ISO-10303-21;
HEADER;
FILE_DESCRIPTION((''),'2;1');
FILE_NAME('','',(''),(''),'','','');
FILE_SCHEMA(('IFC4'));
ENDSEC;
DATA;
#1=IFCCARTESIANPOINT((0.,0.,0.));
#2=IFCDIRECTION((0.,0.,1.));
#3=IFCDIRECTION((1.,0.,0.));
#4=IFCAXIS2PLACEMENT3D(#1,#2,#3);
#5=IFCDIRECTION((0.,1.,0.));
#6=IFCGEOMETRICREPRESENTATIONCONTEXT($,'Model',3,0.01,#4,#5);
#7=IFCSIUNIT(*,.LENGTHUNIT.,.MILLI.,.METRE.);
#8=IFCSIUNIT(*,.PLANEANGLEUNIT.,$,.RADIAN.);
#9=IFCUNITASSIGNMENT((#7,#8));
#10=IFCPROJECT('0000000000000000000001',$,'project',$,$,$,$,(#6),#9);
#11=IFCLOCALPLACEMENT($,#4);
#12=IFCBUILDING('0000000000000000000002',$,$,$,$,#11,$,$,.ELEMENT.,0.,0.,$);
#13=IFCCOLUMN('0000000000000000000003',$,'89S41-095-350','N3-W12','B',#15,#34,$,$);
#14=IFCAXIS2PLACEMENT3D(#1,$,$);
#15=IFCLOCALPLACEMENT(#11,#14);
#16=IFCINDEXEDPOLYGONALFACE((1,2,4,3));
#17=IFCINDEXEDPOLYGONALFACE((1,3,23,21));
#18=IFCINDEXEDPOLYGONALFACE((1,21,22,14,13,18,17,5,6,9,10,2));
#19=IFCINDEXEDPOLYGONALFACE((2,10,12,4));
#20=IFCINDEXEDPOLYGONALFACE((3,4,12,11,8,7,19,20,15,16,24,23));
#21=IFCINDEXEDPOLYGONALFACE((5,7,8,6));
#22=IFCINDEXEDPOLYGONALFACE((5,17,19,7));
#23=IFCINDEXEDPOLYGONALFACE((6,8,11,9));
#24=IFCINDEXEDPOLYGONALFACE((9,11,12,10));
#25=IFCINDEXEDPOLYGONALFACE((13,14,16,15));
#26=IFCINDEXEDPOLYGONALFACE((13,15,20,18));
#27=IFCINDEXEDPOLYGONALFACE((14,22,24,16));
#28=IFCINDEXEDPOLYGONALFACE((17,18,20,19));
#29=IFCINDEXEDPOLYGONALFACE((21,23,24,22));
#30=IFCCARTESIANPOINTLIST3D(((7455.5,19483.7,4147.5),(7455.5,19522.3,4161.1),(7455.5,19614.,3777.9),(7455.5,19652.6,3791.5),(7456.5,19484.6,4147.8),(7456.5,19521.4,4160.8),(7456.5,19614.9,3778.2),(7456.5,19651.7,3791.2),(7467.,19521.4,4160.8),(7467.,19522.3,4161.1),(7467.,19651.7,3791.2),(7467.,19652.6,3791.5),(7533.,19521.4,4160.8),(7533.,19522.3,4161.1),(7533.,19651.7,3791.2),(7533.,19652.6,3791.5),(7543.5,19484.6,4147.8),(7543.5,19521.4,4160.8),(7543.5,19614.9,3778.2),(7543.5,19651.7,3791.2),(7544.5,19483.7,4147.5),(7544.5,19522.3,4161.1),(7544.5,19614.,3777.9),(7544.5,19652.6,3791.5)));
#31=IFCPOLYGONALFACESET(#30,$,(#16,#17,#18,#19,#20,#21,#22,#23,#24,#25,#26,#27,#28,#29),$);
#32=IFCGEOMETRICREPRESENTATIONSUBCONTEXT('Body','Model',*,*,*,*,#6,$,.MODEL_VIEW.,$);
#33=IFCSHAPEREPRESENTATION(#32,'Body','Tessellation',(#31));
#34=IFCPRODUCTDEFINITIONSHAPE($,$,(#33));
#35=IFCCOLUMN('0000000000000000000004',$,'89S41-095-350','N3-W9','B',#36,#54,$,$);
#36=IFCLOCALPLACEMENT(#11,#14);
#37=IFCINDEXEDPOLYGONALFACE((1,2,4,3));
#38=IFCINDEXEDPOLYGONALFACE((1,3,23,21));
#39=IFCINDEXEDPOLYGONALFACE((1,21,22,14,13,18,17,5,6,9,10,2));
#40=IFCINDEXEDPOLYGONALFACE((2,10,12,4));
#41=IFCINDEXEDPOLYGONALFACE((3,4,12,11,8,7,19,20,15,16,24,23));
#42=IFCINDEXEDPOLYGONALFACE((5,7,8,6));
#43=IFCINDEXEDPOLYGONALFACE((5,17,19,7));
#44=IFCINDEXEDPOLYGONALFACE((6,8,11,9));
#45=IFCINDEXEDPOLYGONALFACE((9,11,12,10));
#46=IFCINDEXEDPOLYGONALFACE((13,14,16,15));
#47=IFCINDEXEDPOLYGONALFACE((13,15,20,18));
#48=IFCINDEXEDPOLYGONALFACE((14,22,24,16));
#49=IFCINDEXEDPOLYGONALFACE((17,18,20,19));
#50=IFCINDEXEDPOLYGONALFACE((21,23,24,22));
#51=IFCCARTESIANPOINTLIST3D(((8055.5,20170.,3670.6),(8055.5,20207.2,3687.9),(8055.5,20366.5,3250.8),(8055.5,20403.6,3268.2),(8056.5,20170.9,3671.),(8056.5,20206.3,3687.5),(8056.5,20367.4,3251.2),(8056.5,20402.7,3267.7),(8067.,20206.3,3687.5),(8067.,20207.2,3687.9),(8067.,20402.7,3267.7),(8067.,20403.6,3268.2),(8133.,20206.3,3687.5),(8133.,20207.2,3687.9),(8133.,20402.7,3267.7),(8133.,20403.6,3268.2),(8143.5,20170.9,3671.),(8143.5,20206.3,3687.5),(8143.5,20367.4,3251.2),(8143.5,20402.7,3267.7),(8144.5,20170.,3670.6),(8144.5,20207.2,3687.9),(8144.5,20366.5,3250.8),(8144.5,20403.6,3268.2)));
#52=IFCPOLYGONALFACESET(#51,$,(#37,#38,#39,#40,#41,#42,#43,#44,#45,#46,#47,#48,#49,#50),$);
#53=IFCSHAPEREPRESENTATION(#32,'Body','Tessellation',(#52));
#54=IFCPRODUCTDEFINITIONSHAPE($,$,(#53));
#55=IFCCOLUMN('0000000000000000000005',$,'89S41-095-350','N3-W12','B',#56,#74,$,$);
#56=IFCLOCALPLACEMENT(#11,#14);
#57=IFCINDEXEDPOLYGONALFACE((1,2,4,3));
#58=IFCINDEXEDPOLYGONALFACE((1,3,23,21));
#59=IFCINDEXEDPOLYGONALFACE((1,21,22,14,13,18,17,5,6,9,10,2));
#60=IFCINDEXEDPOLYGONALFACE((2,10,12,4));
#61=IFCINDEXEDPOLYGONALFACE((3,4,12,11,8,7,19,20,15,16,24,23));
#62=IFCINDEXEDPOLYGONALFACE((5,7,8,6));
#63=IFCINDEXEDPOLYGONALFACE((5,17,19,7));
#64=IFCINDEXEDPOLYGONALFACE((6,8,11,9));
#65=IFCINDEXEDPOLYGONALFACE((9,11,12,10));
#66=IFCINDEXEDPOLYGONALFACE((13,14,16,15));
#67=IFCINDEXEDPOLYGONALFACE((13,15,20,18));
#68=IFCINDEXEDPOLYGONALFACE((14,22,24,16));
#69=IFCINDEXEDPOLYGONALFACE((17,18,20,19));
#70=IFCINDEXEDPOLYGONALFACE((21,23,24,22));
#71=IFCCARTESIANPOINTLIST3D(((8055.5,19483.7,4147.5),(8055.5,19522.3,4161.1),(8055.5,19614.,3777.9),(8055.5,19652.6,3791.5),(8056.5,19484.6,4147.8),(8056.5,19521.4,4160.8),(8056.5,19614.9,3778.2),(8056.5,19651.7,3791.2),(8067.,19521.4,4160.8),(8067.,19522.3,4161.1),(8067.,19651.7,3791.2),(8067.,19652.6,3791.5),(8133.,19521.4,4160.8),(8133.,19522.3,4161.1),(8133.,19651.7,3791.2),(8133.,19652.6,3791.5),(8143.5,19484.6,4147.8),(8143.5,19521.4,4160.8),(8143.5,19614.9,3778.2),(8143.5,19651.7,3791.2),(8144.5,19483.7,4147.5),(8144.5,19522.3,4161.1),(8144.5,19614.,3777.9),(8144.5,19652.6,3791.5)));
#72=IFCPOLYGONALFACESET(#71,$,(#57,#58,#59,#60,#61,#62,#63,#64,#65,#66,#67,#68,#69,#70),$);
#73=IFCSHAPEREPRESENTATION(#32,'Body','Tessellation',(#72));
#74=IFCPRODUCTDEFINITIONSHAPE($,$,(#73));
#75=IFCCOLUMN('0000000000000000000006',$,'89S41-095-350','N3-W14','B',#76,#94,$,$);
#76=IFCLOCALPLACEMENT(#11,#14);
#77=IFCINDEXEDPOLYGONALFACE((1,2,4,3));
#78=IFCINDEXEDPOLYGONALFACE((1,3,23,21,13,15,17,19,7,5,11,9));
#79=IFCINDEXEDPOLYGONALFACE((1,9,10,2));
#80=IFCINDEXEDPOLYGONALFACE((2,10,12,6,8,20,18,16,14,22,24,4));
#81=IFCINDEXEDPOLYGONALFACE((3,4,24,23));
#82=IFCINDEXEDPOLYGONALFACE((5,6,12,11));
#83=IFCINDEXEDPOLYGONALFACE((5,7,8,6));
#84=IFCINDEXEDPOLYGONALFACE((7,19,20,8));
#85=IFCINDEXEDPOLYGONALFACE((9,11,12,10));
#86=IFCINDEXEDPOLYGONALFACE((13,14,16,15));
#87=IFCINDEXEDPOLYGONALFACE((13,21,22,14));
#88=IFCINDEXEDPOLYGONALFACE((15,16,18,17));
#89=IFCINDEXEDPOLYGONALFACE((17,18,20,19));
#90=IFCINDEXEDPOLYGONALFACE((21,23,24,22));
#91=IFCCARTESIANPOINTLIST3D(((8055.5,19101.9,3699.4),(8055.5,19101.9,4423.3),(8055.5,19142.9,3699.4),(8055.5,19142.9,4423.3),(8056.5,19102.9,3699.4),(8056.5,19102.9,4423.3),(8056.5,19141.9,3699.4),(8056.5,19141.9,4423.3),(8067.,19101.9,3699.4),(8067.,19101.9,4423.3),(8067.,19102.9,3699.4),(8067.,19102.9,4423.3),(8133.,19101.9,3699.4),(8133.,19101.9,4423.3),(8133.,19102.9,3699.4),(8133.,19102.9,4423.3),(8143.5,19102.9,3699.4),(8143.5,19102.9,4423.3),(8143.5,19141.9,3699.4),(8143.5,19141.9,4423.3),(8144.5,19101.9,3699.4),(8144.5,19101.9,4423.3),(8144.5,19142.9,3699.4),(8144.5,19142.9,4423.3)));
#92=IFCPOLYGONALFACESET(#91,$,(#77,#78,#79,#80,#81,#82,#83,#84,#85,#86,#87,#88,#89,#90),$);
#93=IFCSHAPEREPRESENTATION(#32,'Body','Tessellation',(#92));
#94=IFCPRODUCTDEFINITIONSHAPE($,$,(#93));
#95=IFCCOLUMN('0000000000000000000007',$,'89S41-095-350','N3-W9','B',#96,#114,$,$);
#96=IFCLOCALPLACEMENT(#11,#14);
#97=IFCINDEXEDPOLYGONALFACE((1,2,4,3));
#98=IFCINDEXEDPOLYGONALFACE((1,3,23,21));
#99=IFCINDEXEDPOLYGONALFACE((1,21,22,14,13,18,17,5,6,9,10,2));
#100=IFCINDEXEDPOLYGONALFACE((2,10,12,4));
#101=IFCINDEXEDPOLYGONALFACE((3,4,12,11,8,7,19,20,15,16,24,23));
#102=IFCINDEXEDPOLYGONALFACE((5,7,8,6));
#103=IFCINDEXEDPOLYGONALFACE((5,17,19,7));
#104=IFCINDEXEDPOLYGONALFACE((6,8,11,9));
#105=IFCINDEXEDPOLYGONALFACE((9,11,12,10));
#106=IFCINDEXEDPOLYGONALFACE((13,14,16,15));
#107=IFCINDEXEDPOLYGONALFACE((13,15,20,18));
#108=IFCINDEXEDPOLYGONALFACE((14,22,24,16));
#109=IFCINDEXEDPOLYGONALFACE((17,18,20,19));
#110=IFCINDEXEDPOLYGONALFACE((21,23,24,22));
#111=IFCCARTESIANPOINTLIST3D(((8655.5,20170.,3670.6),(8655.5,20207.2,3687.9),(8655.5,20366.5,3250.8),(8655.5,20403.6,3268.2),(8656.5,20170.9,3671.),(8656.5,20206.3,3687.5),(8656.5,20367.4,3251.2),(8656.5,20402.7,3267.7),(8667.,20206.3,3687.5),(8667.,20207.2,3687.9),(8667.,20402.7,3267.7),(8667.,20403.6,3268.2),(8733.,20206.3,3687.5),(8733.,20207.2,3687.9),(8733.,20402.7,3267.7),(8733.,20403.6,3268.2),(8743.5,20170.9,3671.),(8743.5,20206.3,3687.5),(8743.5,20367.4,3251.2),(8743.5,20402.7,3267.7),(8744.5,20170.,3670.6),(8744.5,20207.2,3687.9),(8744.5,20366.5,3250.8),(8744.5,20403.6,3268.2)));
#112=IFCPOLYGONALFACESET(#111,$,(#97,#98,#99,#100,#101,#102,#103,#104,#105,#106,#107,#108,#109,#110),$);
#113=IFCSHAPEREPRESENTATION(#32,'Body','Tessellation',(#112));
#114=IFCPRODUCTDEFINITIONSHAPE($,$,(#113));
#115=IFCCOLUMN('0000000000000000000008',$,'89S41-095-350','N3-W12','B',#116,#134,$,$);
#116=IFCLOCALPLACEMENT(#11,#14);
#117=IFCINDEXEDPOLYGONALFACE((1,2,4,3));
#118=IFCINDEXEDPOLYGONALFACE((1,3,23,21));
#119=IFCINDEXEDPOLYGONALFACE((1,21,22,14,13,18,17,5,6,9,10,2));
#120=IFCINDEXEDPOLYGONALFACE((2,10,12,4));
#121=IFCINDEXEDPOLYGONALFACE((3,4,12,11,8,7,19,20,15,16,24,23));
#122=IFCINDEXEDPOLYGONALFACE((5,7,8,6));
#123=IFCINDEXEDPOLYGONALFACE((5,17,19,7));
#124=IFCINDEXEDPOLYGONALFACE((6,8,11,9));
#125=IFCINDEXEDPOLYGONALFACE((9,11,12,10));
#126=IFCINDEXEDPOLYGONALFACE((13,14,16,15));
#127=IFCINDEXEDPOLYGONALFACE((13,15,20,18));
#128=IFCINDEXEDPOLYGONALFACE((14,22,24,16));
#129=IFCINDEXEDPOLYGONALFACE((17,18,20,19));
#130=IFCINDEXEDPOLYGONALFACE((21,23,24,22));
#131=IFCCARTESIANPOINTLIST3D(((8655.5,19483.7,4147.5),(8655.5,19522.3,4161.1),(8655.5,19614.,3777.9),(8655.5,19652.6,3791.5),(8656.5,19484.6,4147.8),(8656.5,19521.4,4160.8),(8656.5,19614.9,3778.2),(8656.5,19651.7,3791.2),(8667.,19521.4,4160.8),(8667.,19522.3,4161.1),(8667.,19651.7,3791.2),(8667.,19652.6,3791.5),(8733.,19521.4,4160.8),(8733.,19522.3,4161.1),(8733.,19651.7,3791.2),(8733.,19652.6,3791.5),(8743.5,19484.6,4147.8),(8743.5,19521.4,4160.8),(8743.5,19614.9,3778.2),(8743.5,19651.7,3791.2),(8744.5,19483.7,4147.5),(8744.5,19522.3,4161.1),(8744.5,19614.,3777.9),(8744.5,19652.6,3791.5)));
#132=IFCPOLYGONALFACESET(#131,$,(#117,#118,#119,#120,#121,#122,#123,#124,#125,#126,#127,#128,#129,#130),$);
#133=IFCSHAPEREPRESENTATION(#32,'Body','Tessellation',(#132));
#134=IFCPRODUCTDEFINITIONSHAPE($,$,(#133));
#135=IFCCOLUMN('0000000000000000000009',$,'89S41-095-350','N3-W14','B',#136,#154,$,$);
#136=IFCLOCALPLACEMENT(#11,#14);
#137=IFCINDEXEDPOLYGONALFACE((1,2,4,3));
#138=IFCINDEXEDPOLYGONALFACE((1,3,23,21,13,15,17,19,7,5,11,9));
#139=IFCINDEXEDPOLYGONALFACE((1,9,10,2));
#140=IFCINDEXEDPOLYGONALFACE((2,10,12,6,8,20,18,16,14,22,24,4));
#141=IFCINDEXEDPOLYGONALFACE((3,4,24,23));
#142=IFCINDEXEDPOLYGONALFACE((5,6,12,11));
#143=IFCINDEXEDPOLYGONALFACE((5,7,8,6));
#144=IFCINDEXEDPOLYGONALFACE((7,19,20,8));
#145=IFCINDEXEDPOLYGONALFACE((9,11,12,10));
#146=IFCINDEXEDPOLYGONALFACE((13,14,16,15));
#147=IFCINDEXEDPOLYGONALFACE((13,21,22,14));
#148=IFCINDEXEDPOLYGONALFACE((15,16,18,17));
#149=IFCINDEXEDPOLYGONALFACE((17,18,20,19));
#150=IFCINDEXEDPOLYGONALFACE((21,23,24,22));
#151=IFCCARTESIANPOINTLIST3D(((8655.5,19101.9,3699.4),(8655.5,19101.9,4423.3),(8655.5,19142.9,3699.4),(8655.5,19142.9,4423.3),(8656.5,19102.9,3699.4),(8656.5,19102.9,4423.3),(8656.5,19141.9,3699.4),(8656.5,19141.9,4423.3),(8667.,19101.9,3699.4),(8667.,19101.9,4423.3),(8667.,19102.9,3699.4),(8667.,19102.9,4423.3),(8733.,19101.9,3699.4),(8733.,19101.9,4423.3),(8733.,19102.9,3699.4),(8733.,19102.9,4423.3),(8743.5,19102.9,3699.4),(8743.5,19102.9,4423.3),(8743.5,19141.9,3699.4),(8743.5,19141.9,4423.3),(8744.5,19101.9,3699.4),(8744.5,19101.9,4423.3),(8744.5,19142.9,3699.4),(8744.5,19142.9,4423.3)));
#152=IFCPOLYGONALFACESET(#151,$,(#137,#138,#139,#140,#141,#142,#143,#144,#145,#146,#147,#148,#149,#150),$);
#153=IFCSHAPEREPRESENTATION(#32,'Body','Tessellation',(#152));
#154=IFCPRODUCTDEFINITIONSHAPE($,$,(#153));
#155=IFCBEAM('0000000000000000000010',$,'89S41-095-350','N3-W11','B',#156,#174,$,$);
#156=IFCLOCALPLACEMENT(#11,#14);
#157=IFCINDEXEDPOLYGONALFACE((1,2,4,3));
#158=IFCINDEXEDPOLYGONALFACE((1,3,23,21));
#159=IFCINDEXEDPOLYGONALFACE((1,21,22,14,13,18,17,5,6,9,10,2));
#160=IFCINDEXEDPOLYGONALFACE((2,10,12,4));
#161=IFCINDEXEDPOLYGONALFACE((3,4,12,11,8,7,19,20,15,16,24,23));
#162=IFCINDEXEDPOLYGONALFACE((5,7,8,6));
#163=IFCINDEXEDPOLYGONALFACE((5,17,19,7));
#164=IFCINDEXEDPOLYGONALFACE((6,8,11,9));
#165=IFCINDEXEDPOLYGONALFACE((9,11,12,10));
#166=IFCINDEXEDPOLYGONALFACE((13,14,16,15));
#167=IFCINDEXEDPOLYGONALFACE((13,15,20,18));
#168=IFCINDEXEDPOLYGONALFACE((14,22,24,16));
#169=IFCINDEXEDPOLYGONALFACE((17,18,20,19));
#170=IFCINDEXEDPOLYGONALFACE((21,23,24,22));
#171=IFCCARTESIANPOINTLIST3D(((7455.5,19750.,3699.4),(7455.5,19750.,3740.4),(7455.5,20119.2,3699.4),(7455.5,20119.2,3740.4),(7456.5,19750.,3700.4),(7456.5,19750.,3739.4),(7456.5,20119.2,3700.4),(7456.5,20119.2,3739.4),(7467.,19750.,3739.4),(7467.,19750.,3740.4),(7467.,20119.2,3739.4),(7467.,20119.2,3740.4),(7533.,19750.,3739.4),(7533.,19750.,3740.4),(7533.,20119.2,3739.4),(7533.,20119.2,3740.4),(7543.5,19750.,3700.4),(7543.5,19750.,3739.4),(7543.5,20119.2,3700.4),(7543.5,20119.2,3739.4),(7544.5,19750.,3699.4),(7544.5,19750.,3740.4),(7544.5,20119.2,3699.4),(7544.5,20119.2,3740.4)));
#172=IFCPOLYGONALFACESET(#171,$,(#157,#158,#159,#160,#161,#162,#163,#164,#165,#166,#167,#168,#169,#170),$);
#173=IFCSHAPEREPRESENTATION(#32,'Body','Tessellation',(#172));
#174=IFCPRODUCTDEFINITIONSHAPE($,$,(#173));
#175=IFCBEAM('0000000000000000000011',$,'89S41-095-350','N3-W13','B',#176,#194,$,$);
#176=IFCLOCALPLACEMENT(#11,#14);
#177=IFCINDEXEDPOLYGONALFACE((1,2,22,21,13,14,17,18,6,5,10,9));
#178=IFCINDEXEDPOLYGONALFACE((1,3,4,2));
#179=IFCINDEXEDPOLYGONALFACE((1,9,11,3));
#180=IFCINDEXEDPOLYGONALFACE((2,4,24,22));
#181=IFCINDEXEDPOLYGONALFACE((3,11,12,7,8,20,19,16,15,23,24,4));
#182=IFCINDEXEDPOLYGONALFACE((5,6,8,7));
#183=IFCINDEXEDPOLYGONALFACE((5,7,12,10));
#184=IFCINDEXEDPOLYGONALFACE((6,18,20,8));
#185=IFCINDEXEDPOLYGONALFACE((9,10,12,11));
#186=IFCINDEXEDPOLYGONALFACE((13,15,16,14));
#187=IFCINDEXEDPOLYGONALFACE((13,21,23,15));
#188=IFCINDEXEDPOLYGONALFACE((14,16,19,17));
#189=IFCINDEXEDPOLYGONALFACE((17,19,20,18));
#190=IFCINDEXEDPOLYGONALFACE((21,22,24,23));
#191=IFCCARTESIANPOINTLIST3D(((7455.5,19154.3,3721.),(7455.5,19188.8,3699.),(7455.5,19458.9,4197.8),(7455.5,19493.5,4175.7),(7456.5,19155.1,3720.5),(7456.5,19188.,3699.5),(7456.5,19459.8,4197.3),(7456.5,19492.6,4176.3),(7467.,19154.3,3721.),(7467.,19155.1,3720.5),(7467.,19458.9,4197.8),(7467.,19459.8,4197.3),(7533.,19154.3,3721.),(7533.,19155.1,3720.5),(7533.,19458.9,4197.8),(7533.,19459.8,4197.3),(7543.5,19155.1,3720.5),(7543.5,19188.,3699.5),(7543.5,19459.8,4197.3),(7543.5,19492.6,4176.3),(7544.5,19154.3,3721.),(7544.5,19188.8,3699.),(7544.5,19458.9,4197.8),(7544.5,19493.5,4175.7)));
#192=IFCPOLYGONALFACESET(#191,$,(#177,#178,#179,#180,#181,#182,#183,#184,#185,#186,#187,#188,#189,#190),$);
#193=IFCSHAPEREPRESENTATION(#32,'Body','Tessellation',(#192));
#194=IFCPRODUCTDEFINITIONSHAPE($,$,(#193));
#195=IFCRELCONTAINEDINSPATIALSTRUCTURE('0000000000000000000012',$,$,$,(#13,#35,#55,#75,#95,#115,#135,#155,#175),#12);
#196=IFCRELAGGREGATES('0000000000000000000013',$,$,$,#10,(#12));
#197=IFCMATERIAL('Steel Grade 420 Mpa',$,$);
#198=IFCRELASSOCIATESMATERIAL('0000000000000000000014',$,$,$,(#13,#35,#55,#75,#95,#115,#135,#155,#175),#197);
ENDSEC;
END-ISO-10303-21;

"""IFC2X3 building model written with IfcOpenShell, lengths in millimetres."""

from ifc_helpers import new_model, si_unit, direction, frame, origin, origin_with_axes, origin_2d_with_axis, place, context, subcontext, project, spatial, c_section, extrude, source, transform, mapped, material, element, save


model = new_model("IFC2X3")

# Units and contexts
model_context = context("Model", 3, precision=0.01, world=origin_with_axes(), true_north=direction((0.0, 1.0, 0.0)))
body_context = subcontext(model_context, "Body", "Model", "MODEL_VIEW")
ifc_project = project(units=[si_unit("LENGTHUNIT", "METRE", prefix="MILLI"), si_unit("PLANEANGLEUNIT", "RADIAN")], contexts=[model_context])

# Building
building_placement = place(None, origin_with_axes())
building = spatial("IfcBuilding", under=ifc_project, at=building_placement, CompositionType="ELEMENT", ElevationOfRefHeight=0.0, ElevationOfTerrain=0.0)

# Columns
ifc_material = material(Name="Steel Grade 420 Mpa")
shared_shape_1 = source(origin(), body_context, "Body", "SweptSolid", [
    extrude(c_section(Depth=89.0, Width=41.0, WallThickness=1.0, Girth=11.5, at=origin_2d_with_axis()), origin_with_axes(), (0.0, 0.0, 1.0), 391.9),
])
column_1_placement = place(None, frame((7500.0, 19633.3, 3784.7), z_axis=(0.0, -0.33255, 0.943086), x_axis=(0.0, 0.943086, 0.33255)))
element("IfcColumn", 1, at=column_1_placement, inside=building, material=ifc_material, Name="89S41-095-350", Description="N3-W12", ObjectType="B", context=body_context, shape_type="MappedRepresentation", body=[
    mapped(shared_shape_1, transform((0.0, 0.0, 0.0), scale=1.0)),
])
shared_shape_2 = source(origin(), body_context, "Body", "SweptSolid", [
    extrude(c_section(Depth=89.0, Width=41.0, WallThickness=1.0, Girth=11.5, at=origin_2d_with_axis()), origin_with_axes(), (0.0, 0.0, 1.0), 463.5),
])
column_2_placement = place(None, frame((8100.0, 20385.1, 3259.5), z_axis=(0.0, -0.423875, 0.905721), x_axis=(0.0, 0.905721, 0.423875)))
element("IfcColumn", 2, at=column_2_placement, inside=building, material=ifc_material, Name="89S41-095-350", Description="N3-W9", ObjectType="B", context=body_context, shape_type="MappedRepresentation", body=[
    mapped(shared_shape_2, transform((0.0, 0.0, 0.0), scale=1.0)),
])
shared_shape_3 = source(origin(), body_context, "Body", "SweptSolid", [
    extrude(c_section(Depth=89.0, Width=41.0, WallThickness=1.0, Girth=11.5, at=origin_2d_with_axis()), origin_with_axes(), (0.0, 0.0, 1.0), 391.9),
])
column_3_placement = place(None, frame((8100.0, 19633.3, 3784.7), z_axis=(0.0, -0.33255, 0.943086), x_axis=(0.0, 0.943086, 0.33255)))
element("IfcColumn", 3, at=column_3_placement, inside=building, material=ifc_material, Name="89S41-095-350", Description="N3-W12", ObjectType="B", context=body_context, shape_type="MappedRepresentation", body=[
    mapped(shared_shape_3, transform((0.0, 0.0, 0.0), scale=1.0)),
])
shared_shape_4 = source(origin(), body_context, "Body", "SweptSolid", [
    extrude(c_section(Depth=89.0, Width=41.0, WallThickness=1.0, Girth=11.5, at=origin_2d_with_axis()), origin_with_axes(), (0.0, 0.0, 1.0), 723.9),
])
column_4_placement = place(None, frame((8100.0, 19122.4, 4423.3), z_axis=(0.0, 0.0, -1.0), x_axis=(0.0, -1.0, 0.0)))
element("IfcColumn", 4, at=column_4_placement, inside=building, material=ifc_material, Name="89S41-095-350", Description="N3-W14", ObjectType="B", context=body_context, shape_type="MappedRepresentation", body=[
    mapped(shared_shape_4, transform((0.0, 0.0, 0.0), scale=1.0)),
])
shared_shape_5 = source(origin(), body_context, "Body", "SweptSolid", [
    extrude(c_section(Depth=89.0, Width=41.0, WallThickness=1.0, Girth=11.5, at=origin_2d_with_axis()), origin_with_axes(), (0.0, 0.0, 1.0), 463.5),
])
column_5_placement = place(None, frame((8700.0, 20385.1, 3259.5), z_axis=(0.0, -0.423875, 0.905721), x_axis=(0.0, 0.905721, 0.423875)))
element("IfcColumn", 5, at=column_5_placement, inside=building, material=ifc_material, Name="89S41-095-350", Description="N3-W9", ObjectType="B", context=body_context, shape_type="MappedRepresentation", body=[
    mapped(shared_shape_5, transform((0.0, 0.0, 0.0), scale=1.0)),
])
shared_shape_6 = source(origin(), body_context, "Body", "SweptSolid", [
    extrude(c_section(Depth=89.0, Width=41.0, WallThickness=1.0, Girth=11.5, at=origin_2d_with_axis()), origin_with_axes(), (0.0, 0.0, 1.0), 391.9),
])
column_6_placement = place(None, frame((8700.0, 19633.3, 3784.7), z_axis=(0.0, -0.33255, 0.943086), x_axis=(0.0, 0.943086, 0.33255)))
element("IfcColumn", 6, at=column_6_placement, inside=building, material=ifc_material, Name="89S41-095-350", Description="N3-W12", ObjectType="B", context=body_context, shape_type="MappedRepresentation", body=[
    mapped(shared_shape_6, transform((0.0, 0.0, 0.0), scale=1.0)),
])
shared_shape_7 = source(origin(), body_context, "Body", "SweptSolid", [
    extrude(c_section(Depth=89.0, Width=41.0, WallThickness=1.0, Girth=11.5, at=origin_2d_with_axis()), origin_with_axes(), (0.0, 0.0, 1.0), 723.9),
])
column_7_placement = place(None, frame((8700.0, 19122.4, 4423.3), z_axis=(0.0, 0.0, -1.0), x_axis=(0.0, -1.0, 0.0)))
element("IfcColumn", 7, at=column_7_placement, inside=building, material=ifc_material, Name="89S41-095-350", Description="N3-W14", ObjectType="B", context=body_context, shape_type="MappedRepresentation", body=[
    mapped(shared_shape_7, transform((0.0, 0.0, 0.0), scale=1.0)),
])

# Beams
shared_shape_8 = source(origin(), body_context, "Body", "SweptSolid", [
    extrude(c_section(Depth=89.0, Width=41.0, WallThickness=1.0, Girth=11.5, at=origin_2d_with_axis()), origin_with_axes(), (0.0, 0.0, 1.0), 369.2),
])
beam_1_placement = place(None, frame((7500.0, 20119.2, 3719.9), z_axis=(0.0, -1.0, 0.0), x_axis=(0.0, 0.0, 1.0)))
element("IfcBeam", 8, at=beam_1_placement, inside=building, material=ifc_material, Name="89S41-095-350", Description="N3-W11", ObjectType="B", context=body_context, shape_type="MappedRepresentation", body=[
    mapped(shared_shape_8, transform((0.0, 0.0, 0.0), scale=1.0)),
])
shared_shape_9 = source(origin(), body_context, "Body", "SweptSolid", [
    extrude(c_section(Depth=89.0, Width=41.0, WallThickness=1.0, Girth=11.5, at=origin_2d_with_axis()), origin_with_axes(), (0.0, 0.0, 1.0), 565.8),
])
beam_2_placement = place(None, frame((7500.0, 19476.2, 4186.8), z_axis=(0.0, -0.538498, -0.842627), x_axis=(0.0, -0.842627, 0.538498)))
element("IfcBeam", 9, at=beam_2_placement, inside=building, material=ifc_material, Name="89S41-095-350", Description="N3-W13", ObjectType="B", context=body_context, shape_type="MappedRepresentation", body=[
    mapped(shared_shape_9, transform((0.0, 0.0, 0.0), scale=1.0)),
])

save(model, "model.ifc")
